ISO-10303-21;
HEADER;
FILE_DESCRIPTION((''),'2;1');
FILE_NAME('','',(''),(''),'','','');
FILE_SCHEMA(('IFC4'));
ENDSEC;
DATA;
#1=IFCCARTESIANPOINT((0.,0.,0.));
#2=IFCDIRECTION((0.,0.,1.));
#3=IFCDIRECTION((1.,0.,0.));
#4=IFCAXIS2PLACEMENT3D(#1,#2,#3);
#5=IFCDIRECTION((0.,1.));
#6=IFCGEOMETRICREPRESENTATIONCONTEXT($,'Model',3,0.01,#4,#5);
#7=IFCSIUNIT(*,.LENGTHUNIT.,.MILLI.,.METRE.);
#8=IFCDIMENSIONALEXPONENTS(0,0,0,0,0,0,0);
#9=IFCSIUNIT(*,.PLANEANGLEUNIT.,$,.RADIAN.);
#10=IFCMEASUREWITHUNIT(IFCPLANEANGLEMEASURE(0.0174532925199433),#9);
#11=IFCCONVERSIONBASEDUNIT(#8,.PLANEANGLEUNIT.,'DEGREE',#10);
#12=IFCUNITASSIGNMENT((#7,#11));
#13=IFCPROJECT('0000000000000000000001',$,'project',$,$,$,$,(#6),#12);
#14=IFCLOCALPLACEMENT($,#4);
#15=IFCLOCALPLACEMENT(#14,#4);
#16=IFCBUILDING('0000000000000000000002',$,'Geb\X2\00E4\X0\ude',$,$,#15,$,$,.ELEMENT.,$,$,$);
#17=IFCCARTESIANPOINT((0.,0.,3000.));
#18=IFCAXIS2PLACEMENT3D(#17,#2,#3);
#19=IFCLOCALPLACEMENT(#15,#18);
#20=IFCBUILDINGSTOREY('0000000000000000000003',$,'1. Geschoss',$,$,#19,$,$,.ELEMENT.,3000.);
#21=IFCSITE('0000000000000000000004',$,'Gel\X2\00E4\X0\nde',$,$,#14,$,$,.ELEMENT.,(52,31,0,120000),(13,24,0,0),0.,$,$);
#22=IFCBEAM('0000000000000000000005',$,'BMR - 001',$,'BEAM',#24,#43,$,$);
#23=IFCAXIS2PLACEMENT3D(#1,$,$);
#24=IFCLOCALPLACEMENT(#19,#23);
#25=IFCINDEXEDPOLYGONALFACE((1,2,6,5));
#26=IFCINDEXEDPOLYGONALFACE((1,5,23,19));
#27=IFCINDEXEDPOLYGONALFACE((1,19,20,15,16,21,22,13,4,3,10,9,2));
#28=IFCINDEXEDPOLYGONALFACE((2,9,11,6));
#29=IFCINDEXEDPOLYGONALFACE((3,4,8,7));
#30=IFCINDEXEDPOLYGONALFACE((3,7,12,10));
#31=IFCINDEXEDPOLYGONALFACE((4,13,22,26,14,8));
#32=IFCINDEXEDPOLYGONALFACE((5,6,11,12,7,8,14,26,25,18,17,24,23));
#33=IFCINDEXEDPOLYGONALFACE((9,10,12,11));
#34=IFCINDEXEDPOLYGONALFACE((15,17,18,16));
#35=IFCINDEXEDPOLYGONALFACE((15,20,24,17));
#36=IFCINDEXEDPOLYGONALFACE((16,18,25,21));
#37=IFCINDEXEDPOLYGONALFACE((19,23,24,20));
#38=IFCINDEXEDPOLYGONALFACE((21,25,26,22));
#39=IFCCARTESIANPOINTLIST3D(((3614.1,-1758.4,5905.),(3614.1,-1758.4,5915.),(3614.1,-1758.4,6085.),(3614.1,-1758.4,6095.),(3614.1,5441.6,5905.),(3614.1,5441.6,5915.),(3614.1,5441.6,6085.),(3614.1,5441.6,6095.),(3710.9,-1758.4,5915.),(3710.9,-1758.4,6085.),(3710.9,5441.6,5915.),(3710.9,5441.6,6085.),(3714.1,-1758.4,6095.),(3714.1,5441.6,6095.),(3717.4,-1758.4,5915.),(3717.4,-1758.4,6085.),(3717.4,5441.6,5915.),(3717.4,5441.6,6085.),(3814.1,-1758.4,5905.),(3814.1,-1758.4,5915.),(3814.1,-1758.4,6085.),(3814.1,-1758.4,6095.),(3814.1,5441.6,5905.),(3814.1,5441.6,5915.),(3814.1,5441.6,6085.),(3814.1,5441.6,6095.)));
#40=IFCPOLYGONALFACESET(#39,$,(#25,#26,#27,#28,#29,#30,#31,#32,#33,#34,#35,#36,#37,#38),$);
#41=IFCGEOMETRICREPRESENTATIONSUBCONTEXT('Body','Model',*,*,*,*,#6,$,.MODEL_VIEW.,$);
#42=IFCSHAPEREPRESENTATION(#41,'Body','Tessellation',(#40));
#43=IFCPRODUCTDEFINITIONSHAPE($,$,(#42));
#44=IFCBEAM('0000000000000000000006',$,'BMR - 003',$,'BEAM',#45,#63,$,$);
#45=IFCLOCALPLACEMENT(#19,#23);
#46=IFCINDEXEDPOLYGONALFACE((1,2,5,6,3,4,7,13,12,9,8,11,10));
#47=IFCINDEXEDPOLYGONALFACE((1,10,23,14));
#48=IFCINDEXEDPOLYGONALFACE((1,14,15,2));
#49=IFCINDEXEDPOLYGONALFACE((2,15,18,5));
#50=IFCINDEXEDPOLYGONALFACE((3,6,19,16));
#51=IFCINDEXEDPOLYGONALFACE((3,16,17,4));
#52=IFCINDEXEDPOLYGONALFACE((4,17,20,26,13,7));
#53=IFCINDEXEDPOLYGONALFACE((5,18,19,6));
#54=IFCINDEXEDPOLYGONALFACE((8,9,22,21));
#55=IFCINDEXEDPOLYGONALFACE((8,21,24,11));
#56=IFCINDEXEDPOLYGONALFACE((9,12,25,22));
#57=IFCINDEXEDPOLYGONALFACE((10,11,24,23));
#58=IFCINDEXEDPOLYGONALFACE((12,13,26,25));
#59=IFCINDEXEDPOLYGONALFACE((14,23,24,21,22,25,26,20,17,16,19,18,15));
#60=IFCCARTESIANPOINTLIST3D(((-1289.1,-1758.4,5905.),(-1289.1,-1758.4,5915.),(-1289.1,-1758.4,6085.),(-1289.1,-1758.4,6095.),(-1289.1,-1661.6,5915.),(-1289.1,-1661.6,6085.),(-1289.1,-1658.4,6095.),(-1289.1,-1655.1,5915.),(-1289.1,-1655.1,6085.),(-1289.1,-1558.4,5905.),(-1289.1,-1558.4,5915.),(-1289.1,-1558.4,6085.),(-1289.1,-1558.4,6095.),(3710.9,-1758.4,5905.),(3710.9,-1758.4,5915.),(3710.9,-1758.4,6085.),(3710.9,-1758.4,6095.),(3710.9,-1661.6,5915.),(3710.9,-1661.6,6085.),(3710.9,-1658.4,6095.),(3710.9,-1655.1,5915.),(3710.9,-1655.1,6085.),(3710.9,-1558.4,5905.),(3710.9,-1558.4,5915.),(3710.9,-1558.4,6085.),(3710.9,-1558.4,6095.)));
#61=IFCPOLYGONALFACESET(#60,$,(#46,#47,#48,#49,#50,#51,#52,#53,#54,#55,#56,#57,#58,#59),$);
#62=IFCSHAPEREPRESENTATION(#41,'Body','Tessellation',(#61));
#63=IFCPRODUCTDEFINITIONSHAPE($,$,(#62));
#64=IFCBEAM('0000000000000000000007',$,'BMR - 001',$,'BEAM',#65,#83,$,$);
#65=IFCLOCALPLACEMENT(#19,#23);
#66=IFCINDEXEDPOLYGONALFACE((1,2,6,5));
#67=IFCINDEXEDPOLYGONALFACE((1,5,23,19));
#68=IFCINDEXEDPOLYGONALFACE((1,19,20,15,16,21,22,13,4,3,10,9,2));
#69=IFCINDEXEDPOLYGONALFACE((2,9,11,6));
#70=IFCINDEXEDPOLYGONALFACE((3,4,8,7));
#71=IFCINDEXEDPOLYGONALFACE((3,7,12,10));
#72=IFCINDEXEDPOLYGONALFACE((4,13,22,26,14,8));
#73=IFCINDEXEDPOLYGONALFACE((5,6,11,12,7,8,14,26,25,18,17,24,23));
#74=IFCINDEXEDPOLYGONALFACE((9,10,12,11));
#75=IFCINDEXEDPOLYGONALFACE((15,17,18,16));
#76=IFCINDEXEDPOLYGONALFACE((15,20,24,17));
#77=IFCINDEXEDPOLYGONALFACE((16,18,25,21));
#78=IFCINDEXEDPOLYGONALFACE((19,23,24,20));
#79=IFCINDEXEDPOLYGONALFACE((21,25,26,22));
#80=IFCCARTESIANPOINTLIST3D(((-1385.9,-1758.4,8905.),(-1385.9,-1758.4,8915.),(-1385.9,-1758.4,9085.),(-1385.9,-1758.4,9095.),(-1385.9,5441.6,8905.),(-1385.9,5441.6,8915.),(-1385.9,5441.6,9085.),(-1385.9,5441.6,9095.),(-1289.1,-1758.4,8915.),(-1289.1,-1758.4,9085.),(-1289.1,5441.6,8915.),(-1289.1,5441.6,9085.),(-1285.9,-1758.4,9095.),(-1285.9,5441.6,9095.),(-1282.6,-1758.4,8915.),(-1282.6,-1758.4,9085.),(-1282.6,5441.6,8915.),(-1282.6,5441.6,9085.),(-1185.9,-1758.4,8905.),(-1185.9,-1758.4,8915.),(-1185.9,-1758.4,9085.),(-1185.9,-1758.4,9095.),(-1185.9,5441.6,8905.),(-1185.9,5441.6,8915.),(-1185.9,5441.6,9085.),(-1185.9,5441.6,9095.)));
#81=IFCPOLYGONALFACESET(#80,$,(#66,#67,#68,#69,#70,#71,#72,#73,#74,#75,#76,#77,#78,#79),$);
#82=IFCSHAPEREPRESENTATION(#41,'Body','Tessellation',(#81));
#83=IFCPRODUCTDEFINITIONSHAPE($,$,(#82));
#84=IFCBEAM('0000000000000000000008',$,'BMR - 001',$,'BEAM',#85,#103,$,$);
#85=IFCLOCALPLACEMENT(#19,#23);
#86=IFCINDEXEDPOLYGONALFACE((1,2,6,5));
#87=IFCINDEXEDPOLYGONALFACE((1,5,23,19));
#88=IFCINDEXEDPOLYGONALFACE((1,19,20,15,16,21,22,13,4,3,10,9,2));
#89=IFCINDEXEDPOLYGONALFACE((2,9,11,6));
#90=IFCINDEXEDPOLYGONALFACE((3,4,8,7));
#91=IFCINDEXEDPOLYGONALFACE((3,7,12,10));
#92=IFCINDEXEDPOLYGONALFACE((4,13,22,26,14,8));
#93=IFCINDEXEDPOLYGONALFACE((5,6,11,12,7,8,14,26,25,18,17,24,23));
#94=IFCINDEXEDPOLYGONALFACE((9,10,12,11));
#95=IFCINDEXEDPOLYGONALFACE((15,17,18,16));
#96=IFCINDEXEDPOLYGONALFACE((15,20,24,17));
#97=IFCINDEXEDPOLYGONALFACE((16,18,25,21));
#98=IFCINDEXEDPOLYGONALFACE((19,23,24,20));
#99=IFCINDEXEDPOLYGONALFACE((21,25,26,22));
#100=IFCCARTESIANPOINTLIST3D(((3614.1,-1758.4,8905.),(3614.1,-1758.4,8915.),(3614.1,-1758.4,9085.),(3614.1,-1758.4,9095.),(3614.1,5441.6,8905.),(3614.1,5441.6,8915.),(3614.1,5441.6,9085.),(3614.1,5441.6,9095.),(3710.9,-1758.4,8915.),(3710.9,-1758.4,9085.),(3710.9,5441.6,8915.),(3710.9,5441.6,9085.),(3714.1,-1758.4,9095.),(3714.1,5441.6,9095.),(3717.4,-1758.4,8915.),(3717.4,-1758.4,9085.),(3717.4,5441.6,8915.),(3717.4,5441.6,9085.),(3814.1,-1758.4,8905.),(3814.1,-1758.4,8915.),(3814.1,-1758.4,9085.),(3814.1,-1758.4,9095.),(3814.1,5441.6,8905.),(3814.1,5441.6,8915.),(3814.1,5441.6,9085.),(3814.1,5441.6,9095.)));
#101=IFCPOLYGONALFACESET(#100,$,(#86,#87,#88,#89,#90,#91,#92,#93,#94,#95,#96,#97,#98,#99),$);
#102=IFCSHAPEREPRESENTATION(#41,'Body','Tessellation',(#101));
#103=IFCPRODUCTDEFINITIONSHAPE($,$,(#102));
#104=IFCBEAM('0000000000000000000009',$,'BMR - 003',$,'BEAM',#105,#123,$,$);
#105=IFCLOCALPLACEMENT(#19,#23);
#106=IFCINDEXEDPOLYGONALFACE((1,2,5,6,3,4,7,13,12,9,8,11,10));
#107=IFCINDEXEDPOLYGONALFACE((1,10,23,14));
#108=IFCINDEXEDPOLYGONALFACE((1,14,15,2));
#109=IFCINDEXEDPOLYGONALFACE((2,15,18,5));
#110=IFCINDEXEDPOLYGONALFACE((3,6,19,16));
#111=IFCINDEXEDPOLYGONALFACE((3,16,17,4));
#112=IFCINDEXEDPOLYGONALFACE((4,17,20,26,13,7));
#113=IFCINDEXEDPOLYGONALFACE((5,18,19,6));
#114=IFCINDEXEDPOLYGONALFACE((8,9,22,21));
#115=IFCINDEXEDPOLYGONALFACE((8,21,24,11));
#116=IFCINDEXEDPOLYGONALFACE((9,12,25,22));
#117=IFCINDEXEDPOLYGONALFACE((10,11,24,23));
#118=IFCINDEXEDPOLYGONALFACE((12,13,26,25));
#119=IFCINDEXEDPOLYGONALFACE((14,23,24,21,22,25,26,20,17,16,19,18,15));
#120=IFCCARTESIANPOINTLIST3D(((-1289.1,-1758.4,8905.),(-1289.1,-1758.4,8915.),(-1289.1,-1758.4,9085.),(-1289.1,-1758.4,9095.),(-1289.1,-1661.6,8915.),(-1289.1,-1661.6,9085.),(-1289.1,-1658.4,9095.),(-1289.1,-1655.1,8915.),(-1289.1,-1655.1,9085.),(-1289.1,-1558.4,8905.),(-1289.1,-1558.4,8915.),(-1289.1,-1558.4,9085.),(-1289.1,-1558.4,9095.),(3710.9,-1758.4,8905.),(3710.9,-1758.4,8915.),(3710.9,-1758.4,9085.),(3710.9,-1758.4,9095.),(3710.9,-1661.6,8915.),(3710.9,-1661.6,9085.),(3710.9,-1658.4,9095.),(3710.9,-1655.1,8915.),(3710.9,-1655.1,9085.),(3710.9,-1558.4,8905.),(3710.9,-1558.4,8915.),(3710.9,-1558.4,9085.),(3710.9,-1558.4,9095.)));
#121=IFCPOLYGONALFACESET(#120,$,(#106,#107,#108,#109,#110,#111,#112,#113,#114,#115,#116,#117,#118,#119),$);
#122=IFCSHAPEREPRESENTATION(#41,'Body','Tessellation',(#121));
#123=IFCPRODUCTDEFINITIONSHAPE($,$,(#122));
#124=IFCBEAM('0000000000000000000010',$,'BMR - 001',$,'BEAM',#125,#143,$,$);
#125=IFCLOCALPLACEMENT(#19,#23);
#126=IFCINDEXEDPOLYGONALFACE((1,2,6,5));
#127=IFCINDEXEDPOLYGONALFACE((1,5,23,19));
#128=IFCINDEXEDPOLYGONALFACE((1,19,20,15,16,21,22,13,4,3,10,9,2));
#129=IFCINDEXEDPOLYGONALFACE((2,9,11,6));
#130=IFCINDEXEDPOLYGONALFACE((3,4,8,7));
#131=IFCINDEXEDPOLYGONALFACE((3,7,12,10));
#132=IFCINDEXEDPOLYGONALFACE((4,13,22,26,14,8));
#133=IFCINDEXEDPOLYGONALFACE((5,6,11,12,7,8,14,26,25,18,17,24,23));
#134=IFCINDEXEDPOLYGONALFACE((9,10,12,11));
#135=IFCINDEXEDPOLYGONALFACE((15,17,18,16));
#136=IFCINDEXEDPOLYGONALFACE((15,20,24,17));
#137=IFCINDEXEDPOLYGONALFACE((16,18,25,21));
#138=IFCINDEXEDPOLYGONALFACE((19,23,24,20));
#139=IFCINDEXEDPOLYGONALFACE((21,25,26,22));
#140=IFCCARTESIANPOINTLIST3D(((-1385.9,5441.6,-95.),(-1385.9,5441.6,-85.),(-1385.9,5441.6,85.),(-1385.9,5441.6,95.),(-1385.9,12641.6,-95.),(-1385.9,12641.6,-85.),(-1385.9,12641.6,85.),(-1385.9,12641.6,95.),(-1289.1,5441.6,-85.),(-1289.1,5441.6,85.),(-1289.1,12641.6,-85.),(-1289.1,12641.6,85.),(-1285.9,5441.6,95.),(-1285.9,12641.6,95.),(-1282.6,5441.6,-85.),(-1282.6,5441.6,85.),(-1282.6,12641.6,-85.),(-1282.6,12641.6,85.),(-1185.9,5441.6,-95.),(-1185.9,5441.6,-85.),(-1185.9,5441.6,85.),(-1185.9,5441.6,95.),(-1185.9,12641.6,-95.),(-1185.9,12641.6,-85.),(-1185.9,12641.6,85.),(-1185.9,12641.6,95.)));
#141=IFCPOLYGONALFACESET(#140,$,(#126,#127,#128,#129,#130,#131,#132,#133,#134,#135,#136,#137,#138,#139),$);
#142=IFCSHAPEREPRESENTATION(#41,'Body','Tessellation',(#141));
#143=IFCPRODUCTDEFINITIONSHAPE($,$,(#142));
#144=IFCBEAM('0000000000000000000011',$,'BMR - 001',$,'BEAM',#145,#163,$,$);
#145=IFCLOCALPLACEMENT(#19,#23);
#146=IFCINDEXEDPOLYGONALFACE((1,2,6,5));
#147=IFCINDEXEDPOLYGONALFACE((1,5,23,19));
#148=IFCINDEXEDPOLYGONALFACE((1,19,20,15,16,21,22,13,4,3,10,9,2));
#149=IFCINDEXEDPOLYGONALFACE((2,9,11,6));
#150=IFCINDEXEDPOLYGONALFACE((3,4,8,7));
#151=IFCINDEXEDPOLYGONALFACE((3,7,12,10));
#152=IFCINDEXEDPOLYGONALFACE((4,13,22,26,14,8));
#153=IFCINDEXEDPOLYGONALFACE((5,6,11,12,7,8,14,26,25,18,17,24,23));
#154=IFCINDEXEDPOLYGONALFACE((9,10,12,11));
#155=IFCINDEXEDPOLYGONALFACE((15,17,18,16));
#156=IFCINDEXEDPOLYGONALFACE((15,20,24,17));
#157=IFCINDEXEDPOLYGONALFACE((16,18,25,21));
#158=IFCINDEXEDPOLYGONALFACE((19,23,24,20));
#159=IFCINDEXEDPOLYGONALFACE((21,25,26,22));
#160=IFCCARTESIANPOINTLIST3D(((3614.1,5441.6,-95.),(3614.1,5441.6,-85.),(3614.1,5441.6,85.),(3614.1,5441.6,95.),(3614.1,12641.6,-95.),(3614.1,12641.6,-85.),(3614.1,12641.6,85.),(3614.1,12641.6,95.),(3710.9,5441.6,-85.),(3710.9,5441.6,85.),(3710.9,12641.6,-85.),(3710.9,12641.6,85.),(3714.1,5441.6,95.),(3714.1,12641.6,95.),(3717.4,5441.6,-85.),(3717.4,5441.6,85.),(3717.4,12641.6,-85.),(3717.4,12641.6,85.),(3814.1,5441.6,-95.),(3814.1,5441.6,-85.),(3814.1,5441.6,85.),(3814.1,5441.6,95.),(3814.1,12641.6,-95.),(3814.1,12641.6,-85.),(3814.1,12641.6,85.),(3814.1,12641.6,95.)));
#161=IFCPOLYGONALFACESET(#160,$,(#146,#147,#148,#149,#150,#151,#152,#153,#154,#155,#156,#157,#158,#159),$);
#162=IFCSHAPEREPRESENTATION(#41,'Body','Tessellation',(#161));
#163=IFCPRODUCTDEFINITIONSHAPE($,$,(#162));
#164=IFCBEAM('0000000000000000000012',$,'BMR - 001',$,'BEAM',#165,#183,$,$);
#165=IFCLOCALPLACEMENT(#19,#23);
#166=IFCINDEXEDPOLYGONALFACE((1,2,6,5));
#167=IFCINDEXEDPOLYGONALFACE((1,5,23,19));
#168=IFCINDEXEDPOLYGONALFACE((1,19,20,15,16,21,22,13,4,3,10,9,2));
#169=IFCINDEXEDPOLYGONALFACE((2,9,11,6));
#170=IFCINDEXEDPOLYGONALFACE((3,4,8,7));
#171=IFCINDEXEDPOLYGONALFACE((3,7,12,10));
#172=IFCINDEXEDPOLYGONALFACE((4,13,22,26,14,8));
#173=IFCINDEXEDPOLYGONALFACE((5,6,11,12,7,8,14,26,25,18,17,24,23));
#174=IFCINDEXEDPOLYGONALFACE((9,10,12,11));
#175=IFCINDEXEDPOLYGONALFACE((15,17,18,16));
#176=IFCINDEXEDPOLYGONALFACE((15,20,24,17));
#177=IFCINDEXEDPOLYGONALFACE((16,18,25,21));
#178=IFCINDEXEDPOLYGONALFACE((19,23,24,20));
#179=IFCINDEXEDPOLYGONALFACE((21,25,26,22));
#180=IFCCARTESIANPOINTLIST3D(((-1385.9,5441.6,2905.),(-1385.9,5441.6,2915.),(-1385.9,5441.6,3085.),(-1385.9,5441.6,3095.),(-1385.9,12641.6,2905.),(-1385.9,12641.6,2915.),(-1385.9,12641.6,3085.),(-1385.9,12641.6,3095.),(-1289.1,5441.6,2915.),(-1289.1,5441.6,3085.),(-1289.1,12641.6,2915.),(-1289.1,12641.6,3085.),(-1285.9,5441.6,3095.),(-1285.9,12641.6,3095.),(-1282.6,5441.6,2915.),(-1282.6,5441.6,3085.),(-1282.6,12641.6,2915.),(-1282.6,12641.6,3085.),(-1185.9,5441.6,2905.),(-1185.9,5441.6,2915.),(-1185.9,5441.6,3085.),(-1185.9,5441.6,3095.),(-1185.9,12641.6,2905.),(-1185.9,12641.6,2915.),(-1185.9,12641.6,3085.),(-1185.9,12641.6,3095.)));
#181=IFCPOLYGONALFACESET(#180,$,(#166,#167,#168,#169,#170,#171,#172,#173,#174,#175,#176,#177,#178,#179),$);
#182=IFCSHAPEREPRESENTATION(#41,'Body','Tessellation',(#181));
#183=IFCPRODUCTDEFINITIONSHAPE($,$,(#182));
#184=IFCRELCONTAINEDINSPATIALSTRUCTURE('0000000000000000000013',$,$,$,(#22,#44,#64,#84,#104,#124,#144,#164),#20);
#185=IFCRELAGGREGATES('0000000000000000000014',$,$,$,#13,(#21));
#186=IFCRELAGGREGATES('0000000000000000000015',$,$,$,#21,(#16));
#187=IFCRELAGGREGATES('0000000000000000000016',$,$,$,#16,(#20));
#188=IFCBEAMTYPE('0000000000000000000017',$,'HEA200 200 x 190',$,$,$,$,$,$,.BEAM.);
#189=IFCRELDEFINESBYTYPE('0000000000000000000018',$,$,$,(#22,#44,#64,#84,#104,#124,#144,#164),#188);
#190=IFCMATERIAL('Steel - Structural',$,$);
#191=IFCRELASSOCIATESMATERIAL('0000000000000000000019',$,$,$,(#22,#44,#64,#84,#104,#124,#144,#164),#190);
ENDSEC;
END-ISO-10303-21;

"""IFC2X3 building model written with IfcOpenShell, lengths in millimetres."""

from ifc_helpers import new_model, entity, si_unit, converted_unit, direction, frame, origin_with_axes, place, context, subcontext, project, spatial, polyline, outline, extrude, material, type_object, element, save


model = new_model("IFC2X3")

# Units and contexts
model_context = context("Model", 3, precision=0.01, world=origin_with_axes(), true_north=direction((0.0, 1.0)))
body_context = subcontext(model_context, "Body", "Model", "MODEL_VIEW")
ifc_project = project(units=[si_unit("LENGTHUNIT", "METRE", prefix="MILLI"), converted_unit("PLANEANGLEUNIT", "DEGREE", entity("IfcPlaneAngleMeasure", 0.0174532925199433), si_unit("PLANEANGLEUNIT", "RADIAN"), dimensions=[0, 0, 0, 0, 0, 0, 0])], contexts=[model_context])

# Site, building, storey
site_placement = place(None, origin_with_axes())
site = spatial("IfcSite", under=ifc_project, at=site_placement, Name="Gelände", CompositionType="ELEMENT", RefLatitude=(52, 31, 0, 120000), RefLongitude=(13, 24, 0, 0), RefElevation=0.0)
building_placement = place(site_placement, origin_with_axes())
building = spatial("IfcBuilding", under=site, at=building_placement, Name="Gebäude", CompositionType="ELEMENT")
storey_placement = place(building_placement, frame((0.0, 0.0, 3000.0), z_axis=(0.0, 0.0, 1.0), x_axis=(1.0, 0.0, 0.0)))
storey = spatial("IfcBuildingStorey", under=building, at=storey_placement, Name="1. Geschoss", CompositionType="ELEMENT", Elevation=3000.0)

# Beams
ifc_material = material(Name="Steel - Structural")
beam_type = type_object("IfcBeamType", Name="HEA200 200 x 190", PredefinedType="BEAM")
for number, where, z_axis, x_axis, name in (
    (1, (3714.1, -1758.4, 6000.0), (0.0, 0.0, 1.0), (1.0, 0.0, 0.0), "BMR - 001"),
):
    element("IfcBeam", number, at=place(storey_placement, frame(where, z_axis=z_axis, x_axis=x_axis)), inside=storey, type_object=beam_type, material=ifc_material, Name=name, ObjectType="BEAM", context=body_context, shape_type="SweptSolid", body=[
        extrude(outline(polyline([(0.0, 95.0), (-100.0, 95.0), (-100.0, 85.0), (-3.2, 85.0), (-3.2, -85.0), (-100.0, -85.0), (-100.0, -95.0), (100.0, -95.0), (100.0, -85.0), (3.2, -85.0), (3.2, 85.0), (100.0, 85.0), (100.0, 95.0), (0.0, 95.0)])), frame((0.0, 7200.0, 0.0), z_axis=(0.0, -1.0, 0.0), x_axis=(1.0, 0.0, 0.0)), (0.0, 0.0, 1.0), 7200.0),
    ])
beam_1_placement = place(storey_placement, frame((-1289.1, -1658.4, 6000.0), z_axis=(0.0, 0.0, 1.0), x_axis=(0.0, -1.0, 0.0)))
element("IfcBeam", 2, at=beam_1_placement, inside=storey, type_object=beam_type, material=ifc_material, Name="BMR - 003", ObjectType="BEAM", context=body_context, shape_type="SweptSolid", body=[
    extrude(outline(polyline([(0.0, 95.0), (-100.0, 95.0), (-100.0, 85.0), (-3.2, 85.0), (-3.2, -85.0), (-100.0, -85.0), (-100.0, -95.0), (100.0, -95.0), (100.0, -85.0), (3.2, -85.0), (3.2, 85.0), (100.0, 85.0), (100.0, 95.0), (0.0, 95.0)])), frame((0.0, 5000.0, 0.0), z_axis=(0.0, -1.0, 0.0), x_axis=(1.0, 0.0, 0.0)), (0.0, 0.0, 1.0), 5000.0),
])
for number, where, z_axis, x_axis, name in (
    (3, (-1285.9, -1758.4, 9000.0), (0.0, 0.0, 1.0), (1.0, 0.0, 0.0), "BMR - 001"),
    (4, (3714.1, -1758.4, 9000.0), (0.0, 0.0, 1.0), (1.0, 0.0, 0.0), "BMR - 001"),
):
    element("IfcBeam", number, at=place(storey_placement, frame(where, z_axis=z_axis, x_axis=x_axis)), inside=storey, type_object=beam_type, material=ifc_material, Name=name, ObjectType="BEAM", context=body_context, shape_type="SweptSolid", body=[
        extrude(outline(polyline([(0.0, 95.0), (-100.0, 95.0), (-100.0, 85.0), (-3.2, 85.0), (-3.2, -85.0), (-100.0, -85.0), (-100.0, -95.0), (100.0, -95.0), (100.0, -85.0), (3.2, -85.0), (3.2, 85.0), (100.0, 85.0), (100.0, 95.0), (0.0, 95.0)])), frame((0.0, 7200.0, 0.0), z_axis=(0.0, -1.0, 0.0), x_axis=(1.0, 0.0, 0.0)), (0.0, 0.0, 1.0), 7200.0),
    ])
beam_2_placement = place(storey_placement, frame((-1289.1, -1658.4, 9000.0), z_axis=(0.0, 0.0, 1.0), x_axis=(0.0, -1.0, 0.0)))
element("IfcBeam", 5, at=beam_2_placement, inside=storey, type_object=beam_type, material=ifc_material, Name="BMR - 003", ObjectType="BEAM", context=body_context, shape_type="SweptSolid", body=[
    extrude(outline(polyline([(0.0, 95.0), (-100.0, 95.0), (-100.0, 85.0), (-3.2, 85.0), (-3.2, -85.0), (-100.0, -85.0), (-100.0, -95.0), (100.0, -95.0), (100.0, -85.0), (3.2, -85.0), (3.2, 85.0), (100.0, 85.0), (100.0, 95.0), (0.0, 95.0)])), frame((0.0, 5000.0, 0.0), z_axis=(0.0, -1.0, 0.0), x_axis=(1.0, 0.0, 0.0)), (0.0, 0.0, 1.0), 5000.0),
])
for number, where, z_axis, x_axis, name in (
    (6, (-1285.9, 5441.6, 0.0), (0.0, 0.0, 1.0), (1.0, 0.0, 0.0), "BMR - 001"),
    (7, (3714.1, 5441.6, 0.0), (0.0, 0.0, 1.0), (1.0, 0.0, 0.0), "BMR - 001"),
    (8, (-1285.9, 5441.6, 3000.0), (0.0, 0.0, 1.0), (1.0, 0.0, 0.0), "BMR - 001"),
):
    element("IfcBeam", number, at=place(storey_placement, frame(where, z_axis=z_axis, x_axis=x_axis)), inside=storey, type_object=beam_type, material=ifc_material, Name=name, ObjectType="BEAM", context=body_context, shape_type="SweptSolid", body=[
        extrude(outline(polyline([(0.0, 95.0), (-100.0, 95.0), (-100.0, 85.0), (-3.2, 85.0), (-3.2, -85.0), (-100.0, -85.0), (-100.0, -95.0), (100.0, -95.0), (100.0, -85.0), (3.2, -85.0), (3.2, 85.0), (100.0, 85.0), (100.0, 95.0), (0.0, 95.0)])), frame((0.0, 7200.0, 0.0), z_axis=(0.0, -1.0, 0.0), x_axis=(1.0, 0.0, 0.0)), (0.0, 0.0, 1.0), 7200.0),
    ])

save(model, "model.ifc")
